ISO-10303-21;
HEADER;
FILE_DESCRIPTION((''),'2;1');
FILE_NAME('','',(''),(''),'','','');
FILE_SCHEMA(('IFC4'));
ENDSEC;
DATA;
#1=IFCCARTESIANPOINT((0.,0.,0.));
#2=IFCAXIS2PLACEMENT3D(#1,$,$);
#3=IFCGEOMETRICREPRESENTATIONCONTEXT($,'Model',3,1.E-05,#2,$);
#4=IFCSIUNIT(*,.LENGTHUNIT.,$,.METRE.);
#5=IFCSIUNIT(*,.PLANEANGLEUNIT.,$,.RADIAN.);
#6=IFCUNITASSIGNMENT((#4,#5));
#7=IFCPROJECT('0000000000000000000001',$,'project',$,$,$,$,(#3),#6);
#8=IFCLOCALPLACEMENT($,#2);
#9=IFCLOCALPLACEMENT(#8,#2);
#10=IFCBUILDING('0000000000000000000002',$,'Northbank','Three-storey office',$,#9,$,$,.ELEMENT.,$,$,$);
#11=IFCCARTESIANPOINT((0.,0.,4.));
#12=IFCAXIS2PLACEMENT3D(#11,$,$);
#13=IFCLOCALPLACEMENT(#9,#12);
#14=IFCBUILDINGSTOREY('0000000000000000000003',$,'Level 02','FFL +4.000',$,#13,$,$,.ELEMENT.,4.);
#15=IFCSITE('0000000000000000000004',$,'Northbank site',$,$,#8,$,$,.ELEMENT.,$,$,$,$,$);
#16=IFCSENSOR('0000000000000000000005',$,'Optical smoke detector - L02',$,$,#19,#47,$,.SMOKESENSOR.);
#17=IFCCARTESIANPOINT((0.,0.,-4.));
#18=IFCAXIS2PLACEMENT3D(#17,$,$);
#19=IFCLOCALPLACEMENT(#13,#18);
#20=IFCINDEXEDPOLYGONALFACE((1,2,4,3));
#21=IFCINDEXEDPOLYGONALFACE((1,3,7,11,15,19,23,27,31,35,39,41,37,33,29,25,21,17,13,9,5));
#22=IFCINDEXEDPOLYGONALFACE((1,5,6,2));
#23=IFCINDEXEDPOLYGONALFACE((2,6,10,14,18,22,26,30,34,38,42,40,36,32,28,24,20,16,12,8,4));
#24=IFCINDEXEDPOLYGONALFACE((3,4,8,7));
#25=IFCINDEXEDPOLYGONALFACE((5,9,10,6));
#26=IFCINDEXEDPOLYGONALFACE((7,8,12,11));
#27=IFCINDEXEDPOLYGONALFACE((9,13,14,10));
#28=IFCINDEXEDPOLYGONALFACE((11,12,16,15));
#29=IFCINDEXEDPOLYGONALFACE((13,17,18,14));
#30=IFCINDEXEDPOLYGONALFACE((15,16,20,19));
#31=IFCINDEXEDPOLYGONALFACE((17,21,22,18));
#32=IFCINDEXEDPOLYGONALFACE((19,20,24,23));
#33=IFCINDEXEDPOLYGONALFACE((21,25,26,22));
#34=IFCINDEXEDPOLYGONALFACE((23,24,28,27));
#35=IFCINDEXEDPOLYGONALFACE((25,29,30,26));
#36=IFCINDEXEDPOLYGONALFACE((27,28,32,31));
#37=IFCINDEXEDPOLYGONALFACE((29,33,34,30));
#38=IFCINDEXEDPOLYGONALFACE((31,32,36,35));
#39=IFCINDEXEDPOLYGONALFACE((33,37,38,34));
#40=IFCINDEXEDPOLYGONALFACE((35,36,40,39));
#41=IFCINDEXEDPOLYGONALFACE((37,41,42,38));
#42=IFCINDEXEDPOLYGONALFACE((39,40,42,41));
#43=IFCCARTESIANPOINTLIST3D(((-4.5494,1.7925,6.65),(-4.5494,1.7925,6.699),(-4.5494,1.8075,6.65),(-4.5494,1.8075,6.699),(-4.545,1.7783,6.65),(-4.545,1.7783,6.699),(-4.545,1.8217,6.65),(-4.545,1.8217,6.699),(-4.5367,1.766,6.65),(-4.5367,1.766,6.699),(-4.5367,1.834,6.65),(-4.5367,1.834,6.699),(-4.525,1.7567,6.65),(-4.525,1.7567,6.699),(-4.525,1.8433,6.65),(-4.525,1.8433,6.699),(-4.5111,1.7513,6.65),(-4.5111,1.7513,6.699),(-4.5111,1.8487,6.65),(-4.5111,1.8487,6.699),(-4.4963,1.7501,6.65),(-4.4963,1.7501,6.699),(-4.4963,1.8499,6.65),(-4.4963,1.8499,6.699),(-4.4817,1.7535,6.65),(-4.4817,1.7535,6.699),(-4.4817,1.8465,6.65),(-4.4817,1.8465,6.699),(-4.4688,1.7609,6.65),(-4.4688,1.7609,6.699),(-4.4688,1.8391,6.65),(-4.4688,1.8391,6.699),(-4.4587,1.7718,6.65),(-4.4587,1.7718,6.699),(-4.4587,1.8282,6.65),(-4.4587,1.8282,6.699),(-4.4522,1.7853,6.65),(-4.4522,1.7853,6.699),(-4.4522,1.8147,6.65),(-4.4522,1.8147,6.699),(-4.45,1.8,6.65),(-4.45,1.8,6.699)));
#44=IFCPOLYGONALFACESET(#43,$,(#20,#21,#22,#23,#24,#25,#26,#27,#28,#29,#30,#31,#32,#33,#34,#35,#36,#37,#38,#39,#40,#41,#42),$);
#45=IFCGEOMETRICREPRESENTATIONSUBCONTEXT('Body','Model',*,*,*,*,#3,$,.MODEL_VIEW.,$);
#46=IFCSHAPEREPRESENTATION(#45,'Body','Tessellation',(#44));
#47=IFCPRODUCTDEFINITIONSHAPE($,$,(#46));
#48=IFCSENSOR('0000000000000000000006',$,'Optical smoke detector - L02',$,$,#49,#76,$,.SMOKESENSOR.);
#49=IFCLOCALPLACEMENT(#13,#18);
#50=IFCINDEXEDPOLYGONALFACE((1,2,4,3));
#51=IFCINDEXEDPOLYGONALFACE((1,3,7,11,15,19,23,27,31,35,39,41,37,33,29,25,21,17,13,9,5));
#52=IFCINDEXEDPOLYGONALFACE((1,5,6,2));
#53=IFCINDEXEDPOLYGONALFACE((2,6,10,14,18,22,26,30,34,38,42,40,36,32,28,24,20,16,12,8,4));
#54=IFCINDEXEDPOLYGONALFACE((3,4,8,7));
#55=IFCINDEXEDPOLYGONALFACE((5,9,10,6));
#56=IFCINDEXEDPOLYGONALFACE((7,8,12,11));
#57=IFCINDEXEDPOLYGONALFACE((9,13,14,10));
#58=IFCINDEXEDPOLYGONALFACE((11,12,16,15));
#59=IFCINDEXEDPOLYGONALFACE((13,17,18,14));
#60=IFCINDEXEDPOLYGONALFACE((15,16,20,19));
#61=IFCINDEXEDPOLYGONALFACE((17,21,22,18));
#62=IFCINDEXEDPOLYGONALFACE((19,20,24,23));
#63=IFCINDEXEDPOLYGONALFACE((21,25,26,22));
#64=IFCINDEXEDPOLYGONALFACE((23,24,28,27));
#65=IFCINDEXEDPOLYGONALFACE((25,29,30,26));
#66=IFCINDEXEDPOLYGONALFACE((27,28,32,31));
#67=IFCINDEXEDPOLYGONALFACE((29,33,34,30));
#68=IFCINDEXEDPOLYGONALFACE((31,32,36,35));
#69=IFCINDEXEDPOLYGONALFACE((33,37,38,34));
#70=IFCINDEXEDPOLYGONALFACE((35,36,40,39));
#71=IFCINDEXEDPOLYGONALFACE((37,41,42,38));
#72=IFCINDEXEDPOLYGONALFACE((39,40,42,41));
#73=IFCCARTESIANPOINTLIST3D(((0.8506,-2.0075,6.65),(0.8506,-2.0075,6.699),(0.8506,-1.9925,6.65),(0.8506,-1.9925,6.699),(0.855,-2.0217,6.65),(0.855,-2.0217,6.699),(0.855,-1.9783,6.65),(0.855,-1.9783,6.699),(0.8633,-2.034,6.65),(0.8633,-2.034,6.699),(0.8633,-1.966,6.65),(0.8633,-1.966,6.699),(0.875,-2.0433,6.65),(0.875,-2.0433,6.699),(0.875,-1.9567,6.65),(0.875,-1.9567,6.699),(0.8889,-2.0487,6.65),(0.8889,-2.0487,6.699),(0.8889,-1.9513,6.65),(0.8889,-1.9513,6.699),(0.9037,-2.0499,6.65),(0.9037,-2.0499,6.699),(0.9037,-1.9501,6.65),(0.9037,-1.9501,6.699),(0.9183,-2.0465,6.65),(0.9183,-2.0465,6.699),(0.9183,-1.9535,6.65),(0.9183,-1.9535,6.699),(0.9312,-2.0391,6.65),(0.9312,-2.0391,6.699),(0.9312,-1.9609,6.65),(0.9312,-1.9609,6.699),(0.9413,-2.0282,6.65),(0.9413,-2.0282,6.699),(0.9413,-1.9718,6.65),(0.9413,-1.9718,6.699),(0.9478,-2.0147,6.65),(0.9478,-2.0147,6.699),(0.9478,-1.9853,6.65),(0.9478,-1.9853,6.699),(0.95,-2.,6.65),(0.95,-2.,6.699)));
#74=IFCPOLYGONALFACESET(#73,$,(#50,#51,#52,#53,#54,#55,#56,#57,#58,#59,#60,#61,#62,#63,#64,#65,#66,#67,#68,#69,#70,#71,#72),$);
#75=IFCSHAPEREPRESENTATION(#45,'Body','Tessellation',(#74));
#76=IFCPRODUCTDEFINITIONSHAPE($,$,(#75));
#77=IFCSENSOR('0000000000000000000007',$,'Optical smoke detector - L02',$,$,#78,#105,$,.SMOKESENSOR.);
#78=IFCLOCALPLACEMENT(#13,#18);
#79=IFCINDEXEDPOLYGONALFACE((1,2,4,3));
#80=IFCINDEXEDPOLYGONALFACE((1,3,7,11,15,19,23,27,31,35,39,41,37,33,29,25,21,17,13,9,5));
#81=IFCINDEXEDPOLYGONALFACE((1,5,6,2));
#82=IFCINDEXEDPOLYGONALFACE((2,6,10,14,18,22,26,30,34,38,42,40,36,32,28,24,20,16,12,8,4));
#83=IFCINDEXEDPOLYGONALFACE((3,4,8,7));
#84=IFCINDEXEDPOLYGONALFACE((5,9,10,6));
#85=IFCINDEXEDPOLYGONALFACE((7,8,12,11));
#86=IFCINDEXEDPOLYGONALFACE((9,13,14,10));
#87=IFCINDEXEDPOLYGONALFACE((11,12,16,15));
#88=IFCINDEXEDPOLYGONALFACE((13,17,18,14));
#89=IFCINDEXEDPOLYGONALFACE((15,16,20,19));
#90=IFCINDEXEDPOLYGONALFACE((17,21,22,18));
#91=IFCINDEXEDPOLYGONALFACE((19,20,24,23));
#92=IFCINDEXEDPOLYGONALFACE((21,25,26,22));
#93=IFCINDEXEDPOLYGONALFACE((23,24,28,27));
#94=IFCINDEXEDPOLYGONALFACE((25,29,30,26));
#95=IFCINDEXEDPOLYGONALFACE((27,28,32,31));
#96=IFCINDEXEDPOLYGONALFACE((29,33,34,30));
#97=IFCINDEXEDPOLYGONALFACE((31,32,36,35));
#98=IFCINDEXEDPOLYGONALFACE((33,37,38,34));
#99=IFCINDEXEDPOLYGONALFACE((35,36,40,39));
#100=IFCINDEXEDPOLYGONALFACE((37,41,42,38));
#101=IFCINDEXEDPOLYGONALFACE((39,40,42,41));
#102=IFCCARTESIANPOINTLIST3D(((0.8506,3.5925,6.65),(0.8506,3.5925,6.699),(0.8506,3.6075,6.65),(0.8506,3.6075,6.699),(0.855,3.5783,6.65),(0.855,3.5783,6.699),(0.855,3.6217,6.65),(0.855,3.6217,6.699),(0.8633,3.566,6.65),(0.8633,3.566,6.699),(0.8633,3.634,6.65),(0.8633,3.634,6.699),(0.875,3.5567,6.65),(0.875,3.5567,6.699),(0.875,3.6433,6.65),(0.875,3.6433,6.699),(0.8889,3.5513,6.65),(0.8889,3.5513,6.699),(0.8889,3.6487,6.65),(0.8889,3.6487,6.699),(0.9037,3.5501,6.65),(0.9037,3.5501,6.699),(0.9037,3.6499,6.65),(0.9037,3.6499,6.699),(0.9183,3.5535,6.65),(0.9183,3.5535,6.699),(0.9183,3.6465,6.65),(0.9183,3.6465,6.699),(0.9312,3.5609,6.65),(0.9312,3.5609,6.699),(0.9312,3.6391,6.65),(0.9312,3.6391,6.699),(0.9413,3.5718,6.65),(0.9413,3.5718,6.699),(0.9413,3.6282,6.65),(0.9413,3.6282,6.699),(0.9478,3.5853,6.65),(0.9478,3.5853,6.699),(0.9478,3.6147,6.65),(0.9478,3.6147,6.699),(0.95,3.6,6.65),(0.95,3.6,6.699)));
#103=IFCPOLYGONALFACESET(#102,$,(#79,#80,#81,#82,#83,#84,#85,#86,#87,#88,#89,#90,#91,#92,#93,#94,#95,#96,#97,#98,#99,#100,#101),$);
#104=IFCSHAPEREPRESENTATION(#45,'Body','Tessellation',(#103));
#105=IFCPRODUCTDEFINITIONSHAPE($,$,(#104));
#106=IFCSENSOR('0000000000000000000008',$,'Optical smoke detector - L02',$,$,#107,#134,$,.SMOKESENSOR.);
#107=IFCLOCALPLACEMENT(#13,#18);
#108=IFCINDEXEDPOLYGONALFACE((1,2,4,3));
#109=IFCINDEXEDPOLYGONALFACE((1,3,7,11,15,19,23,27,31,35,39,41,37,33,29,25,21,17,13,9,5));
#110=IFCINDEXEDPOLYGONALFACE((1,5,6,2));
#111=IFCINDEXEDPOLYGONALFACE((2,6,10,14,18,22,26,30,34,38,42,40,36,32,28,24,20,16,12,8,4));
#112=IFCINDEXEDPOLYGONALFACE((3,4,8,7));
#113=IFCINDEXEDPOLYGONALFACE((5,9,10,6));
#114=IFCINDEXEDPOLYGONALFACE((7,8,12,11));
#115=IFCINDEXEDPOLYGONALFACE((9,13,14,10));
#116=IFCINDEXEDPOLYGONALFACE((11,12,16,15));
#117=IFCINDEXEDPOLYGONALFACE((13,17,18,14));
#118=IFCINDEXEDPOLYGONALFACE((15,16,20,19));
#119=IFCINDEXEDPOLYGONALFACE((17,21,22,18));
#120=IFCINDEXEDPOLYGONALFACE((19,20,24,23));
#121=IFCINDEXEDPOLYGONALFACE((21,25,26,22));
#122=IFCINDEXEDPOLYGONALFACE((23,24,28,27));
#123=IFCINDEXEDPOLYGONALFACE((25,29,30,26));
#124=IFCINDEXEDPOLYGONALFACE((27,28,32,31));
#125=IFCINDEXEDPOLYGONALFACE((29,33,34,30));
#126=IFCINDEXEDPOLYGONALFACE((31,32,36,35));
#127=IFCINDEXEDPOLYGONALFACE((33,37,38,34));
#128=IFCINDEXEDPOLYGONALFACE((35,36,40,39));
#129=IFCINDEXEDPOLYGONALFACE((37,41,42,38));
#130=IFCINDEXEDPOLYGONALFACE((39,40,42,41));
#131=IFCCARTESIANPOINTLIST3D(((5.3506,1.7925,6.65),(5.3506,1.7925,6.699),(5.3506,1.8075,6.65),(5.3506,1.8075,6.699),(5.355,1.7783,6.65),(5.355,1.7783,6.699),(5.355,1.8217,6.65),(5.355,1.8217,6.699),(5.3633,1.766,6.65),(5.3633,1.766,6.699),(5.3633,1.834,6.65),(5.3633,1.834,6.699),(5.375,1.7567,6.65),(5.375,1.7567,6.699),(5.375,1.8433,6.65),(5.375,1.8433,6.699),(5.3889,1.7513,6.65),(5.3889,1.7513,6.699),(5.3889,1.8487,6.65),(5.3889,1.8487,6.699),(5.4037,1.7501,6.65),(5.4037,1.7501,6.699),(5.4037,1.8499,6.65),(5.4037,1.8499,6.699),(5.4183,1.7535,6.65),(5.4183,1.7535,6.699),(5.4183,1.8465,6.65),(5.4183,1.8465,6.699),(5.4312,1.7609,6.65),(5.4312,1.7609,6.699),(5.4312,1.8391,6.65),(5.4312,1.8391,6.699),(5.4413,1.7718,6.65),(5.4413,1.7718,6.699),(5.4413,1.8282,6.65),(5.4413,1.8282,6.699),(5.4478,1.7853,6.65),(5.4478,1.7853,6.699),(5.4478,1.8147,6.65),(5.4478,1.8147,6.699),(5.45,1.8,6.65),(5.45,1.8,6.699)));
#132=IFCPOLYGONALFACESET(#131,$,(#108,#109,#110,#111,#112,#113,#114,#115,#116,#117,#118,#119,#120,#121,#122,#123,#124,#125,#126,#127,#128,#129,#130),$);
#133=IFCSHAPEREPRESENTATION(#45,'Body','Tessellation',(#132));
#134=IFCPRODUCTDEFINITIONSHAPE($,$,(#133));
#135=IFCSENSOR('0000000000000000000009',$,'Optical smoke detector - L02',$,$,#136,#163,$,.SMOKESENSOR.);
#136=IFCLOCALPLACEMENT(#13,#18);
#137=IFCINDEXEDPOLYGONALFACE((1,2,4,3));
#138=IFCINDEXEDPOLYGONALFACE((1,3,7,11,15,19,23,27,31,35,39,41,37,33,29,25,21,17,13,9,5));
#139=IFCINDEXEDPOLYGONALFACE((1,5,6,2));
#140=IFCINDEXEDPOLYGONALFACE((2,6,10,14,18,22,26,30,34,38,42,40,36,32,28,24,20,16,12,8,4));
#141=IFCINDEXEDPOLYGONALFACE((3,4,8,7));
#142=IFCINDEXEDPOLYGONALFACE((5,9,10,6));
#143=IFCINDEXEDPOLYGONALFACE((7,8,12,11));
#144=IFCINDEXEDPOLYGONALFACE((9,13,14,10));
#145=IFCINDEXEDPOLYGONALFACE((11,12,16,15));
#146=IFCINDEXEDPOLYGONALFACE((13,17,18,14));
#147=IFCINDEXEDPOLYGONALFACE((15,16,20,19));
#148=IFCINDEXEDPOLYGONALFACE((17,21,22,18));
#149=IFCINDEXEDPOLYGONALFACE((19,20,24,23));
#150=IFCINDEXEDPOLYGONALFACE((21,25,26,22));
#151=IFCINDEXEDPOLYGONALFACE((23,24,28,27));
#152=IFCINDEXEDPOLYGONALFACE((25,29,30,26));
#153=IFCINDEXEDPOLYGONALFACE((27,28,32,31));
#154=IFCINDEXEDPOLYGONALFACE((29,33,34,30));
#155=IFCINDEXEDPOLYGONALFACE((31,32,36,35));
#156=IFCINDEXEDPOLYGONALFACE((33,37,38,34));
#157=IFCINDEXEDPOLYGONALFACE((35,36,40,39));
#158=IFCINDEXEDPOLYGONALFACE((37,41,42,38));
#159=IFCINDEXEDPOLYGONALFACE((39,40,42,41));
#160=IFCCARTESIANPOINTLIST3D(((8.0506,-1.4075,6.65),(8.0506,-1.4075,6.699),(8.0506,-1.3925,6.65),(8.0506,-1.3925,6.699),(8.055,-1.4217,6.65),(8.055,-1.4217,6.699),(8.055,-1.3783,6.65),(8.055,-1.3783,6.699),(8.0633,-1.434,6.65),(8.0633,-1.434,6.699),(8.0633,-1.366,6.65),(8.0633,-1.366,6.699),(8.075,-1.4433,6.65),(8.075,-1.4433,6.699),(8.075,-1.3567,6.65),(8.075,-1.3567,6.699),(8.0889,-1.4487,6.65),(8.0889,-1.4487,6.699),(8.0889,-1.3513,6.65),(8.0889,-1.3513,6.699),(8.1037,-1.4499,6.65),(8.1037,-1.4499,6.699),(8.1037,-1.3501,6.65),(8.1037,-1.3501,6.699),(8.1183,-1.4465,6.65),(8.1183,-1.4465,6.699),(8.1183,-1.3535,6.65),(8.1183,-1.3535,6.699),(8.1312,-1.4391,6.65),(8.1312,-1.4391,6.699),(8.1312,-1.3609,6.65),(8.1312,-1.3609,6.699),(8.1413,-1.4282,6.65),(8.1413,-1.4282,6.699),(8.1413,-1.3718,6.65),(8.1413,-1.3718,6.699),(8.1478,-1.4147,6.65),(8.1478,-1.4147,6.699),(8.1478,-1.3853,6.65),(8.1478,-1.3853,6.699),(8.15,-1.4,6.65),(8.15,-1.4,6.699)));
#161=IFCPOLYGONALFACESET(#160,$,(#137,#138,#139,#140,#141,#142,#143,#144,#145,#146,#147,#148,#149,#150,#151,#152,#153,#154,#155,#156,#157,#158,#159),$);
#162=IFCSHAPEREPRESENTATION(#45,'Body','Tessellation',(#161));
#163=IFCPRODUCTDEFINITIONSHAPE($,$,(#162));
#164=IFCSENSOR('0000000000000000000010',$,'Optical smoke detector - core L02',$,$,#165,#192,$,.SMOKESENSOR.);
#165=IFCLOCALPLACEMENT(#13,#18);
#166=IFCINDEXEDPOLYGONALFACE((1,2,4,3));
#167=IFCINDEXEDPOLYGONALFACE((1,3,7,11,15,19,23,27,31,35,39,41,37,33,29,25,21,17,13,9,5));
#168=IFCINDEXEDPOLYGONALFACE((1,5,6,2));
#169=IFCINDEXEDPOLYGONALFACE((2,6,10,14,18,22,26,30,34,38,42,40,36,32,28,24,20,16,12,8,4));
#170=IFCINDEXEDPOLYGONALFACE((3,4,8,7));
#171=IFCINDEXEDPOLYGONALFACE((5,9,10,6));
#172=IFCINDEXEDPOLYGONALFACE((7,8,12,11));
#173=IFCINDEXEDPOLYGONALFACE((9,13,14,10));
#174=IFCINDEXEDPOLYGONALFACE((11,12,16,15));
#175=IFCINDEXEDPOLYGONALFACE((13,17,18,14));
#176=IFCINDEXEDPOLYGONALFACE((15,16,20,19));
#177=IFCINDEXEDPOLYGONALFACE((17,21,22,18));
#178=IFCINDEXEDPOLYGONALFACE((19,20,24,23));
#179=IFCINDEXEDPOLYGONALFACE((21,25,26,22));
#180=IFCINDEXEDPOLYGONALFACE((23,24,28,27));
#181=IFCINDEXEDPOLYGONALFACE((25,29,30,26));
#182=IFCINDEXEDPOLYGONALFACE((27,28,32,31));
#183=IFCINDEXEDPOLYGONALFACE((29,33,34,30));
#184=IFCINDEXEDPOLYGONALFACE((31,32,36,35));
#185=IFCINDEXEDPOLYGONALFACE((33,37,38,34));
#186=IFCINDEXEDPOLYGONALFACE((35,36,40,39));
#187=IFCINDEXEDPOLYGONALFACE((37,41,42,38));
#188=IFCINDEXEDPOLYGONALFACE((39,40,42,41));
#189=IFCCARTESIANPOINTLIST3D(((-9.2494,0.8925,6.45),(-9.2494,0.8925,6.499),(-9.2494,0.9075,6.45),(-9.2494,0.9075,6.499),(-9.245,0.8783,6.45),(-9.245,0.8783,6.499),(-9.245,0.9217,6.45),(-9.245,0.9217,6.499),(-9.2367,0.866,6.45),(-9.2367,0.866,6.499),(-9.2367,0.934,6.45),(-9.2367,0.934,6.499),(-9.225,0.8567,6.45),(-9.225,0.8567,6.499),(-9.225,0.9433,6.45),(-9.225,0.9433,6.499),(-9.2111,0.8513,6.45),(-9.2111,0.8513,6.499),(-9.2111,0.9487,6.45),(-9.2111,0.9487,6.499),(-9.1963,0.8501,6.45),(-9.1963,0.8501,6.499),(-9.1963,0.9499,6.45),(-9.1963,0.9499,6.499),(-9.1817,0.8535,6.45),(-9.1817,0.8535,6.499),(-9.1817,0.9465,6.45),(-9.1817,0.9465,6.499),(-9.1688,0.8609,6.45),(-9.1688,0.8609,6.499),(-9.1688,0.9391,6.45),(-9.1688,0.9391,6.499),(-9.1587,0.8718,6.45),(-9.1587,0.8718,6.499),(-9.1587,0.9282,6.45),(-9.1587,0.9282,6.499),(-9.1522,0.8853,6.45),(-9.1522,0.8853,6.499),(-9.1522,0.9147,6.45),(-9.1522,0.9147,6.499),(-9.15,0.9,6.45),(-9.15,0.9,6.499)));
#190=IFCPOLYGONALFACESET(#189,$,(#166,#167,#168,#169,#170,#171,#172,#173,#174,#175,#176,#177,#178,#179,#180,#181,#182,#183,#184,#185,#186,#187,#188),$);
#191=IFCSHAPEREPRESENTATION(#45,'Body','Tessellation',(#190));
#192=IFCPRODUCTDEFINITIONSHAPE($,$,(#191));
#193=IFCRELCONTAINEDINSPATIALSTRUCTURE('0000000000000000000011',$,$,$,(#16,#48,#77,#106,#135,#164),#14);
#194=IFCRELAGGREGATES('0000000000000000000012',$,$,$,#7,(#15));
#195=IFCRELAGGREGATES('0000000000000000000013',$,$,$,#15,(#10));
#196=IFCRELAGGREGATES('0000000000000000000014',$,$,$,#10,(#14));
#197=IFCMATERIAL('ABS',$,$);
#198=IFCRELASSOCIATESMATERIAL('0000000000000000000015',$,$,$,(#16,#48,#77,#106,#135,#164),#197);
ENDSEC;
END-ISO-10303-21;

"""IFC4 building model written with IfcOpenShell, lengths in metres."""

from ifc_helpers import new_model, si_unit, frame, origin, place, context, subcontext, project, spatial, circle, extrude, material, element, save


model = new_model("IFC4")

# Units and contexts
model_context = context("Model", 3, precision=1e-05, world=origin())
body_context = subcontext(model_context, "Body", "Model", "MODEL_VIEW")
ifc_project = project(units=[si_unit("LENGTHUNIT", "METRE"), si_unit("PLANEANGLEUNIT", "RADIAN")], contexts=[model_context])

# Site, building, storey
site_placement = place(None, origin())
site = spatial("IfcSite", under=ifc_project, at=site_placement, Name="Northbank site", CompositionType="ELEMENT")
building_placement = place(site_placement, origin())
building = spatial("IfcBuilding", under=site, at=building_placement, Name="Northbank", Description="Three-storey office", CompositionType="ELEMENT")
storey_placement = place(building_placement, frame((0.0, 0.0, 4.0)))
storey = spatial("IfcBuildingStorey", under=building, at=storey_placement, Name="Level 02", Description="FFL +4.000", CompositionType="ELEMENT", Elevation=4.0)

# Sensors
ifc_material_1 = material(Name="ABS")
sensor_1_placement = place(storey_placement, frame((0.0, 0.0, -4.0)))
element("IfcSensor", 1, at=sensor_1_placement, inside=storey, material=ifc_material_1, Name="Optical smoke detector - L02", PredefinedType="SMOKESENSOR", context=body_context, shape_type="SweptSolid", body=[
    extrude(circle(Radius=0.05), frame((-4.5, 1.8, 6.65), z_axis=(0.0, 0.0, 1.0), x_axis=(1.0, 0.0, 0.0)), (0.0, 0.0, 1.0), 0.049),
])
sensor_2_placement = place(storey_placement, frame((0.0, 0.0, -4.0)))
element("IfcSensor", 2, at=sensor_2_placement, inside=storey, material=ifc_material_1, Name="Optical smoke detector - L02", PredefinedType="SMOKESENSOR", context=body_context, shape_type="SweptSolid", body=[
    extrude(circle(Radius=0.05), frame((0.9, -2.0, 6.65), z_axis=(0.0, 0.0, 1.0), x_axis=(1.0, 0.0, 0.0)), (0.0, 0.0, 1.0), 0.049),
])
sensor_3_placement = place(storey_placement, frame((0.0, 0.0, -4.0)))
element("IfcSensor", 3, at=sensor_3_placement, inside=storey, material=ifc_material_1, Name="Optical smoke detector - L02", PredefinedType="SMOKESENSOR", context=body_context, shape_type="SweptSolid", body=[
    extrude(circle(Radius=0.05), frame((0.9, 3.6, 6.65), z_axis=(0.0, 0.0, 1.0), x_axis=(1.0, 0.0, 0.0)), (0.0, 0.0, 1.0), 0.049),
])
sensor_4_placement = place(storey_placement, frame((0.0, 0.0, -4.0)))
element("IfcSensor", 4, at=sensor_4_placement, inside=storey, material=ifc_material_1, Name="Optical smoke detector - L02", PredefinedType="SMOKESENSOR", context=body_context, shape_type="SweptSolid", body=[
    extrude(circle(Radius=0.05), frame((5.4, 1.8, 6.65), z_axis=(0.0, 0.0, 1.0), x_axis=(1.0, 0.0, 0.0)), (0.0, 0.0, 1.0), 0.049),
])
sensor_5_placement = place(storey_placement, frame((0.0, 0.0, -4.0)))
element("IfcSensor", 5, at=sensor_5_placement, inside=storey, material=ifc_material_1, Name="Optical smoke detector - L02", PredefinedType="SMOKESENSOR", context=body_context, shape_type="SweptSolid", body=[
    extrude(circle(Radius=0.05), frame((8.1, -1.4, 6.65), z_axis=(0.0, 0.0, 1.0), x_axis=(1.0, 0.0, 0.0)), (0.0, 0.0, 1.0), 0.049),
])
sensor_6_placement = place(storey_placement, frame((0.0, 0.0, -4.0)))
element("IfcSensor", 6, at=sensor_6_placement, inside=storey, material=ifc_material_1, Name="Optical smoke detector - core L02", PredefinedType="SMOKESENSOR", context=body_context, shape_type="SweptSolid", body=[
    extrude(circle(Radius=0.05), frame((-9.2, 0.9, 6.45), z_axis=(0.0, 0.0, 1.0), x_axis=(1.0, 0.0, 0.0)), (0.0, 0.0, 1.0), 0.049),
])

save(model, "model.ifc")
